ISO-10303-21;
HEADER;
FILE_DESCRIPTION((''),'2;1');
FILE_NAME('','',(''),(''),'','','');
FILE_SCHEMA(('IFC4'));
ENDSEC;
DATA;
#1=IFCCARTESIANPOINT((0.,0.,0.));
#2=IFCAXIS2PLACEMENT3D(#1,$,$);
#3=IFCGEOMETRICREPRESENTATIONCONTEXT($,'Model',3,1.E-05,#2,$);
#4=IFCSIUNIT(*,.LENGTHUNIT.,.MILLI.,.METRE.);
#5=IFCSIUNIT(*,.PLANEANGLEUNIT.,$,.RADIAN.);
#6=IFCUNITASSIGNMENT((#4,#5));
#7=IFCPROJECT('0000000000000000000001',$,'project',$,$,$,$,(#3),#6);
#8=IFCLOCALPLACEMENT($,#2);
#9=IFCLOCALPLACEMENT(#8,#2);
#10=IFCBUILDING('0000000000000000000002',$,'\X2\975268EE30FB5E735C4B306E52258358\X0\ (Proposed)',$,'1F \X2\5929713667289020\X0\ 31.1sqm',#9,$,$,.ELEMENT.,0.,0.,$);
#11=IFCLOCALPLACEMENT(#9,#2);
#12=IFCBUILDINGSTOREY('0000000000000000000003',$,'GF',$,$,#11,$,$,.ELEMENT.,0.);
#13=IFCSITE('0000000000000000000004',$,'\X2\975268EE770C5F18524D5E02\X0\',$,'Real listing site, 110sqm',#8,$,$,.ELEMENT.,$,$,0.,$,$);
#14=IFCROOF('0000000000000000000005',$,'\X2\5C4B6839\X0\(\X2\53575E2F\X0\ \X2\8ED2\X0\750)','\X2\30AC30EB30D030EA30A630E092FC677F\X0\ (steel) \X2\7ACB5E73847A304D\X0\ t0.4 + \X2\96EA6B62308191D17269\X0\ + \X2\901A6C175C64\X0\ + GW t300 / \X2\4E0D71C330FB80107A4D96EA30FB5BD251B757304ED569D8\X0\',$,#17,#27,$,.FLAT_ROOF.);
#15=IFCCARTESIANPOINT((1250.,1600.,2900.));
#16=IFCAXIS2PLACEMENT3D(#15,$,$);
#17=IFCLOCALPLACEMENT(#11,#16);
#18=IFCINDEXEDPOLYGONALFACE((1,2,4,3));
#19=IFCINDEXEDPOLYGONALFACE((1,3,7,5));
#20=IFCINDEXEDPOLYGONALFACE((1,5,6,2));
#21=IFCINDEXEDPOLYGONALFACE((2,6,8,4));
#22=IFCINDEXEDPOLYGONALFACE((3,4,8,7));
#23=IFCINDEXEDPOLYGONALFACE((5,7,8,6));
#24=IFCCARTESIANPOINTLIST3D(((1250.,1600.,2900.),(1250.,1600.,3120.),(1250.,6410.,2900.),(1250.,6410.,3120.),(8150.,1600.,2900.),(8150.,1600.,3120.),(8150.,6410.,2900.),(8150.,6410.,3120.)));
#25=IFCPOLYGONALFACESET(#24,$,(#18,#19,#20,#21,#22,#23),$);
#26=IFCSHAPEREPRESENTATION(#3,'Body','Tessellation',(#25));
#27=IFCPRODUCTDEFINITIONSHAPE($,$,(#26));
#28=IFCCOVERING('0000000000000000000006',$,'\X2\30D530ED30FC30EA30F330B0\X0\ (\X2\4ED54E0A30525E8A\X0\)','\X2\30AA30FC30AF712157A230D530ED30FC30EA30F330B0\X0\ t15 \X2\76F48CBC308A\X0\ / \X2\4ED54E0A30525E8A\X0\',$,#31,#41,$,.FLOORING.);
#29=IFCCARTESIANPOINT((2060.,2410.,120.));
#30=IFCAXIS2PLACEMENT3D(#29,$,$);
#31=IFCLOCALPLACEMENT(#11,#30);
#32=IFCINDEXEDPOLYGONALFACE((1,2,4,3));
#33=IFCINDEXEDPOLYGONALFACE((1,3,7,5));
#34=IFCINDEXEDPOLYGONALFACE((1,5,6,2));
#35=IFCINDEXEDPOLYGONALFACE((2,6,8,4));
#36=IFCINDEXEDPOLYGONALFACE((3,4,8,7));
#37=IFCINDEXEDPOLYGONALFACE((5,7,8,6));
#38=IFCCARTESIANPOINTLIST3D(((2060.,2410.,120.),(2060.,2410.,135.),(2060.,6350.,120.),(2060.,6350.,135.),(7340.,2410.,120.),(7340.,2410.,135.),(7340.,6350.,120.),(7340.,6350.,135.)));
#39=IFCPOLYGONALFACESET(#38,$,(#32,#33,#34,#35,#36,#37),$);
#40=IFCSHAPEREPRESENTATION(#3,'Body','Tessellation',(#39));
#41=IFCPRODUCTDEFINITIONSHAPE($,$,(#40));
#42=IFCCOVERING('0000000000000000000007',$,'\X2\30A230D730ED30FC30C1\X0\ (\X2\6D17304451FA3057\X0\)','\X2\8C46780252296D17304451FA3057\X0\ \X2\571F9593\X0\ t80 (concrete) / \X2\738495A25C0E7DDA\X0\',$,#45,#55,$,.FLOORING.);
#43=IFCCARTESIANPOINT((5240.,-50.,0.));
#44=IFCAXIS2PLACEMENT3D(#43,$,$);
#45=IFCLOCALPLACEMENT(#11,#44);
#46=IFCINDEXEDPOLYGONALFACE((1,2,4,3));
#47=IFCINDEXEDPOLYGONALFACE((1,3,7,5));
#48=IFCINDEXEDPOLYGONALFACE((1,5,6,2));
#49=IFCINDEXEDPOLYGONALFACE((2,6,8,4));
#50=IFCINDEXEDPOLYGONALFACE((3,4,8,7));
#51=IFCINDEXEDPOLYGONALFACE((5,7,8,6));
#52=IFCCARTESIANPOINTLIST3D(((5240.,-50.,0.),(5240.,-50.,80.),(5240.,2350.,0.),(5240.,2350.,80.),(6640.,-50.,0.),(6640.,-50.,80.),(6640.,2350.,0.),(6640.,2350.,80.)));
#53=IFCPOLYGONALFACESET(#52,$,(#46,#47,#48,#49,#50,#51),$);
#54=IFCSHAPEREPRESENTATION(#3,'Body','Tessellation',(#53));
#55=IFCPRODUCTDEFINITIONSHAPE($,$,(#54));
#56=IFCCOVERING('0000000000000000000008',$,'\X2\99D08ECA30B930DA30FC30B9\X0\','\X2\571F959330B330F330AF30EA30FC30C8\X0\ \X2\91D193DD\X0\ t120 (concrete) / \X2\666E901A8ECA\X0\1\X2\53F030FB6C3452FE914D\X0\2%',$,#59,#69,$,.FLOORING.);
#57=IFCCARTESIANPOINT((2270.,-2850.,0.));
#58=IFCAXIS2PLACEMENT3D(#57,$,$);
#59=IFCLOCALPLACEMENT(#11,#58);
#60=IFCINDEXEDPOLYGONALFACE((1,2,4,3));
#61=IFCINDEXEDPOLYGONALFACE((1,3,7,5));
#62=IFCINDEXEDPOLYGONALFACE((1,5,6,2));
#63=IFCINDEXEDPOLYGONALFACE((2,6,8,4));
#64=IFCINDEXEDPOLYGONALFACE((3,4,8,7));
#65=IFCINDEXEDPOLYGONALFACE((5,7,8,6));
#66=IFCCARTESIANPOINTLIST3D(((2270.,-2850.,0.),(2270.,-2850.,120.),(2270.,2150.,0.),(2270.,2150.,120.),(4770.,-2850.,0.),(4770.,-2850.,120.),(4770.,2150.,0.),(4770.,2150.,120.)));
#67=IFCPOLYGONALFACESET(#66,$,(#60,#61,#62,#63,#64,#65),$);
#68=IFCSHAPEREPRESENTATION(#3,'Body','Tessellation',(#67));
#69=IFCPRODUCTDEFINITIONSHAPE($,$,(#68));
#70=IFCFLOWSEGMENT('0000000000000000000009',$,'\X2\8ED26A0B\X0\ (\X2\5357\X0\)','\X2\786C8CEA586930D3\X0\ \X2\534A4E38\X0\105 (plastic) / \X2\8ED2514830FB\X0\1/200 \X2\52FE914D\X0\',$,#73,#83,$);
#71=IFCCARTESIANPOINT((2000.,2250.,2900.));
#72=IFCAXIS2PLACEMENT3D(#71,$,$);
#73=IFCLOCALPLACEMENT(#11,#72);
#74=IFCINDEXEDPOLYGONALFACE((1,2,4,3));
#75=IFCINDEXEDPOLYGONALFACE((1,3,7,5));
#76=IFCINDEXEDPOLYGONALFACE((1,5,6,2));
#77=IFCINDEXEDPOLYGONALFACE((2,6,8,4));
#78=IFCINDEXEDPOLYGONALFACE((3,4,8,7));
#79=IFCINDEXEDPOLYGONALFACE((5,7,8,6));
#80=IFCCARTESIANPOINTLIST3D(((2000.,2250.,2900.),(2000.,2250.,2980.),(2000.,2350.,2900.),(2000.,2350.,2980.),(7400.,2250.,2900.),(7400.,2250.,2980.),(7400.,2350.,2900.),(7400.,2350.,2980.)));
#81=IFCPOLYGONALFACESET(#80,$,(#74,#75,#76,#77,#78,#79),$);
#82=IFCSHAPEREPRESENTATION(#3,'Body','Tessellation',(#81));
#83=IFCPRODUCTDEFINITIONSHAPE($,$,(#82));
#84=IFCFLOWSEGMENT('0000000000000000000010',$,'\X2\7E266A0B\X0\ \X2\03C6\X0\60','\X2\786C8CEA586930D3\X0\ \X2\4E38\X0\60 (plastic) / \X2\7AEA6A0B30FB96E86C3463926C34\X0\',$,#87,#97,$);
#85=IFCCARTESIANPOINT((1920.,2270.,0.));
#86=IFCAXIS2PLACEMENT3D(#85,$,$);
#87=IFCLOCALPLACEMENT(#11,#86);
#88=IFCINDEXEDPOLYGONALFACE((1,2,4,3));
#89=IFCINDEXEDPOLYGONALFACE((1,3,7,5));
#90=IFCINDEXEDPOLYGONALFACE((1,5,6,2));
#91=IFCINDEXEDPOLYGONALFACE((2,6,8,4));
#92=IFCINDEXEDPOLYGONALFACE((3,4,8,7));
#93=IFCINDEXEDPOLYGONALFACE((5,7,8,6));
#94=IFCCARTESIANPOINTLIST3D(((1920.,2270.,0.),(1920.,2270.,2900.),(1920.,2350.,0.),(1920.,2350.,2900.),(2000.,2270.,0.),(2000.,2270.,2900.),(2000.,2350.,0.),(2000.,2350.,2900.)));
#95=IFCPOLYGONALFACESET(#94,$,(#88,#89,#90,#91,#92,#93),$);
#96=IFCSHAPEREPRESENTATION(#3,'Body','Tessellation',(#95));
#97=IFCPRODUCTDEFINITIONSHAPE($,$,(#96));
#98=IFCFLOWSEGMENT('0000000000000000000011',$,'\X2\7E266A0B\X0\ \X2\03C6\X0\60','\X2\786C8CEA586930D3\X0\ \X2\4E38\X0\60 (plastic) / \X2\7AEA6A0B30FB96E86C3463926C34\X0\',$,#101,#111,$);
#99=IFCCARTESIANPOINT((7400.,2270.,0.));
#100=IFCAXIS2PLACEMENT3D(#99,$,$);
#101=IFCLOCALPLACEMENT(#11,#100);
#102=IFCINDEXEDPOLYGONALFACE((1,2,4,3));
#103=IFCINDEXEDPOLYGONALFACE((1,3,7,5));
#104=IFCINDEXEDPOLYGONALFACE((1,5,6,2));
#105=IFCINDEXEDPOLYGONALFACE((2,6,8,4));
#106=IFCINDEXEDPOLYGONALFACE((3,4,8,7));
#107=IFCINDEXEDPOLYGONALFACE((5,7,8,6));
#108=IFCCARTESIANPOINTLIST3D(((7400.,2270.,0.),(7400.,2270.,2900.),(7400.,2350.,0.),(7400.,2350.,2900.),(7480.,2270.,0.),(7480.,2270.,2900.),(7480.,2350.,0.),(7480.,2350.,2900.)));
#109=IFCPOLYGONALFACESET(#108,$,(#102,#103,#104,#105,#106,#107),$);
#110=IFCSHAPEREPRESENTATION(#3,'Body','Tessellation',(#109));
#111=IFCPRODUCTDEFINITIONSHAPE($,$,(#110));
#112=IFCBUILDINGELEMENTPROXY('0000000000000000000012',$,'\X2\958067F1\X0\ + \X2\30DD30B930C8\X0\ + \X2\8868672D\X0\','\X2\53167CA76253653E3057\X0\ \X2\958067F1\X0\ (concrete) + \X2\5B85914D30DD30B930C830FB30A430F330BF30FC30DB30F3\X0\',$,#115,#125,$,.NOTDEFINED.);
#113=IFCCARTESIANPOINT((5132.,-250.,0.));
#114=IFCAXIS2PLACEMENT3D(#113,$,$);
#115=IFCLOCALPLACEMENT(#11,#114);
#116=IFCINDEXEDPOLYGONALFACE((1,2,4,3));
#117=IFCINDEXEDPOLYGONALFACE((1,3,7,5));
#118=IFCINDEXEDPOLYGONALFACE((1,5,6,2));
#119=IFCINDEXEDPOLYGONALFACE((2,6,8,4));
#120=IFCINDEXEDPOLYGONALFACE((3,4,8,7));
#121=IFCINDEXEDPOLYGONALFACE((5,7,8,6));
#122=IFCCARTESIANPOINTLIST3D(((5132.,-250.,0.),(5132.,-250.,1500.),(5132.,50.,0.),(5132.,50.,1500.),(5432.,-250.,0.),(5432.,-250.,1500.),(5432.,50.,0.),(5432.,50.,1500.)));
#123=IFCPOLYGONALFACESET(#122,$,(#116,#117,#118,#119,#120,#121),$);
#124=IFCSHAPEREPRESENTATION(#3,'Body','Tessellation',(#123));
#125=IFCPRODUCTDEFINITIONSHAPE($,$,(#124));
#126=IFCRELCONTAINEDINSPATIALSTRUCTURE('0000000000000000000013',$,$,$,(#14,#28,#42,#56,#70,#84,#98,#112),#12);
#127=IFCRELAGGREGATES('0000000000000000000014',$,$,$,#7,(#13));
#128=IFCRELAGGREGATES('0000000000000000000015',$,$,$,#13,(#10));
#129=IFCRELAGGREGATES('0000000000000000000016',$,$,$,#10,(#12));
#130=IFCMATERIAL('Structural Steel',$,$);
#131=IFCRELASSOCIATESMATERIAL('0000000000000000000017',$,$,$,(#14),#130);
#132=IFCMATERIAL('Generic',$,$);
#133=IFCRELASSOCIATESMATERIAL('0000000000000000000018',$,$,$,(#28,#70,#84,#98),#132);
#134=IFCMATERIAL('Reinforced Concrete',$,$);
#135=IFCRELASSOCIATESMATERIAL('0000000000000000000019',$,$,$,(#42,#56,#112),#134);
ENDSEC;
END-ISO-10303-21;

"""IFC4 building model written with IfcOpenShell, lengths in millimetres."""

from ifc_helpers import new_model, si_unit, frame, frame_2d, origin, place, context, project, spatial, rectangle, extrude, material, element, save


model = new_model("IFC4")

# Units and contexts
model_context = context("Model", 3, precision=1e-05, world=origin())
ifc_project = project(units=[si_unit("LENGTHUNIT", "METRE", prefix="MILLI"), si_unit("PLANEANGLEUNIT", "RADIAN")], contexts=[model_context])

# Site, building, storey
site_placement = place(None, origin())
site = spatial("IfcSite", under=ifc_project, at=site_placement, Name="青森県弘前市", ObjectType="Real listing site, 110sqm", CompositionType="ELEMENT", RefElevation=0.0)
building_placement = place(site_placement, origin())
building = spatial("IfcBuilding", under=site, at=building_placement, Name="青森・平屋の別荘 (Proposed)", ObjectType="1F 天然木造 31.1sqm", CompositionType="ELEMENT", ElevationOfRefHeight=0.0, ElevationOfTerrain=0.0)
storey_placement = place(building_placement, origin())
storey = spatial("IfcBuildingStorey", under=building, at=storey_placement, Name="GF", CompositionType="ELEMENT", Elevation=0.0)

# Shared definitions
ifc_material_1 = material(Name="Reinforced Concrete")

# Roof
ifc_material_2 = material(Name="Structural Steel")
roof_placement = place(storey_placement, frame((1250.0, 1600.0, 2900.0)))
element("IfcRoof", 1, at=roof_placement, inside=storey, material=ifc_material_2, Name="屋根(南帯 軒750)", Description="ガルバリウム鋼板 (steel) 立平葺き t0.4 + 雪止め金物 + 通気層 + GW t300 / 不燃・耐積雪・寒冷地仕様", PredefinedType="FLAT_ROOF", context=model_context, shape_type="SweptSolid", body=[
    extrude(rectangle(XDim=6900.0, YDim=4810.0, at=frame_2d((3450.0, 2405.0))), frame((1250.0, 1600.0, 2900.0)), (0.0, 0.0, 1.0), 220.0),
])

# Coverings
ifc_material_3 = material(Name="Generic")
covering_1_placement = place(storey_placement, frame((2060.0, 2410.0, 120.0)))
element("IfcCovering", 2, at=covering_1_placement, inside=storey, material=ifc_material_3, Name="フローリング (仕上げ床)", Description="オーク無垢フローリング t15 直貼り / 仕上げ床", PredefinedType="FLOORING", context=model_context, shape_type="SweptSolid", body=[
    extrude(rectangle(XDim=5280.0, YDim=3940.0, at=frame_2d((2640.0, 1970.0))), frame((2060.0, 2410.0, 120.0)), (0.0, 0.0, 1.0), 15.0),
])
covering_2_placement = place(storey_placement, frame((5240.0, -50.0, 0.0)))
element("IfcCovering", 3, at=covering_2_placement, inside=storey, material=ifc_material_1, Name="アプローチ (洗い出し)", Description="豆砂利洗い出し 土間 t80 (concrete) / 玄関導線", PredefinedType="FLOORING", context=model_context, shape_type="SweptSolid", body=[
    extrude(rectangle(XDim=1400.0, YDim=2400.0, at=frame_2d((700.0, 1200.0))), frame((5240.0, -50.0, 0.0)), (0.0, 0.0, 1.0), 80.0),
])
covering_3_placement = place(storey_placement, frame((2270.0, -2850.0, 0.0)))
element("IfcCovering", 4, at=covering_3_placement, inside=storey, material=ifc_material_1, Name="駐車スペース", Description="土間コンクリート 金鏝 t120 (concrete) / 普通車1台・水勾配2%", PredefinedType="FLOORING", context=model_context, shape_type="SweptSolid", body=[
    extrude(rectangle(XDim=2500.0, YDim=5000.0, at=frame_2d((1250.0, 2500.0))), frame((2270.0, -2850.0, 0.0)), (0.0, 0.0, 1.0), 120.0),
])

# Flow segments
flow_segment_1_placement = place(storey_placement, frame((2000.0, 2250.0, 2900.0)))
element("IfcFlowSegment", 5, at=flow_segment_1_placement, inside=storey, material=ifc_material_3, Name="軒樋 (南)", Description="硬質塩ビ 半丸105 (plastic) / 軒先・1/200 勾配", context=model_context, shape_type="SweptSolid", body=[
    extrude(rectangle(XDim=5400.0, YDim=100.0, at=frame_2d((2700.0, 50.0))), frame((2000.0, 2250.0, 2900.0)), (0.0, 0.0, 1.0), 80.0),
])
flow_segment_2_placement = place(storey_placement, frame((1920.0, 2270.0, 0.0)))
element("IfcFlowSegment", 6, at=flow_segment_2_placement, inside=storey, material=ifc_material_3, Name="縦樋 φ60", Description="硬質塩ビ 丸60 (plastic) / 竪樋・雨水排水", context=model_context, shape_type="SweptSolid", body=[
    extrude(rectangle(XDim=80.0, YDim=80.0, at=frame_2d((40.0, 40.0))), frame((1920.0, 2270.0, 0.0)), (0.0, 0.0, 1.0), 2900.0),
])
flow_segment_3_placement = place(storey_placement, frame((7400.0, 2270.0, 0.0)))
element("IfcFlowSegment", 7, at=flow_segment_3_placement, inside=storey, material=ifc_material_3, Name="縦樋 φ60", Description="硬質塩ビ 丸60 (plastic) / 竪樋・雨水排水", context=model_context, shape_type="SweptSolid", body=[
    extrude(rectangle(XDim=80.0, YDim=80.0, at=frame_2d((40.0, 40.0))), frame((7400.0, 2270.0, 0.0)), (0.0, 0.0, 1.0), 2900.0),
])

# Building element proxy
proxy_placement = place(storey_placement, frame((5132.0, -250.0, 0.0)))
element("IfcBuildingElementProxy", 8, at=proxy_placement, inside=storey, material=ifc_material_1, Name="門柱 + ポスト + 表札", Description="化粧打放し 門柱 (concrete) + 宅配ポスト・インターホン", PredefinedType="NOTDEFINED", context=model_context, shape_type="SweptSolid", body=[
    extrude(rectangle(XDim=300.0, YDim=300.0, at=frame_2d((150.0, 150.0))), frame((5132.0, -250.0, 0.0)), (0.0, 0.0, 1.0), 1500.0),
])

save(model, "model.ifc")
